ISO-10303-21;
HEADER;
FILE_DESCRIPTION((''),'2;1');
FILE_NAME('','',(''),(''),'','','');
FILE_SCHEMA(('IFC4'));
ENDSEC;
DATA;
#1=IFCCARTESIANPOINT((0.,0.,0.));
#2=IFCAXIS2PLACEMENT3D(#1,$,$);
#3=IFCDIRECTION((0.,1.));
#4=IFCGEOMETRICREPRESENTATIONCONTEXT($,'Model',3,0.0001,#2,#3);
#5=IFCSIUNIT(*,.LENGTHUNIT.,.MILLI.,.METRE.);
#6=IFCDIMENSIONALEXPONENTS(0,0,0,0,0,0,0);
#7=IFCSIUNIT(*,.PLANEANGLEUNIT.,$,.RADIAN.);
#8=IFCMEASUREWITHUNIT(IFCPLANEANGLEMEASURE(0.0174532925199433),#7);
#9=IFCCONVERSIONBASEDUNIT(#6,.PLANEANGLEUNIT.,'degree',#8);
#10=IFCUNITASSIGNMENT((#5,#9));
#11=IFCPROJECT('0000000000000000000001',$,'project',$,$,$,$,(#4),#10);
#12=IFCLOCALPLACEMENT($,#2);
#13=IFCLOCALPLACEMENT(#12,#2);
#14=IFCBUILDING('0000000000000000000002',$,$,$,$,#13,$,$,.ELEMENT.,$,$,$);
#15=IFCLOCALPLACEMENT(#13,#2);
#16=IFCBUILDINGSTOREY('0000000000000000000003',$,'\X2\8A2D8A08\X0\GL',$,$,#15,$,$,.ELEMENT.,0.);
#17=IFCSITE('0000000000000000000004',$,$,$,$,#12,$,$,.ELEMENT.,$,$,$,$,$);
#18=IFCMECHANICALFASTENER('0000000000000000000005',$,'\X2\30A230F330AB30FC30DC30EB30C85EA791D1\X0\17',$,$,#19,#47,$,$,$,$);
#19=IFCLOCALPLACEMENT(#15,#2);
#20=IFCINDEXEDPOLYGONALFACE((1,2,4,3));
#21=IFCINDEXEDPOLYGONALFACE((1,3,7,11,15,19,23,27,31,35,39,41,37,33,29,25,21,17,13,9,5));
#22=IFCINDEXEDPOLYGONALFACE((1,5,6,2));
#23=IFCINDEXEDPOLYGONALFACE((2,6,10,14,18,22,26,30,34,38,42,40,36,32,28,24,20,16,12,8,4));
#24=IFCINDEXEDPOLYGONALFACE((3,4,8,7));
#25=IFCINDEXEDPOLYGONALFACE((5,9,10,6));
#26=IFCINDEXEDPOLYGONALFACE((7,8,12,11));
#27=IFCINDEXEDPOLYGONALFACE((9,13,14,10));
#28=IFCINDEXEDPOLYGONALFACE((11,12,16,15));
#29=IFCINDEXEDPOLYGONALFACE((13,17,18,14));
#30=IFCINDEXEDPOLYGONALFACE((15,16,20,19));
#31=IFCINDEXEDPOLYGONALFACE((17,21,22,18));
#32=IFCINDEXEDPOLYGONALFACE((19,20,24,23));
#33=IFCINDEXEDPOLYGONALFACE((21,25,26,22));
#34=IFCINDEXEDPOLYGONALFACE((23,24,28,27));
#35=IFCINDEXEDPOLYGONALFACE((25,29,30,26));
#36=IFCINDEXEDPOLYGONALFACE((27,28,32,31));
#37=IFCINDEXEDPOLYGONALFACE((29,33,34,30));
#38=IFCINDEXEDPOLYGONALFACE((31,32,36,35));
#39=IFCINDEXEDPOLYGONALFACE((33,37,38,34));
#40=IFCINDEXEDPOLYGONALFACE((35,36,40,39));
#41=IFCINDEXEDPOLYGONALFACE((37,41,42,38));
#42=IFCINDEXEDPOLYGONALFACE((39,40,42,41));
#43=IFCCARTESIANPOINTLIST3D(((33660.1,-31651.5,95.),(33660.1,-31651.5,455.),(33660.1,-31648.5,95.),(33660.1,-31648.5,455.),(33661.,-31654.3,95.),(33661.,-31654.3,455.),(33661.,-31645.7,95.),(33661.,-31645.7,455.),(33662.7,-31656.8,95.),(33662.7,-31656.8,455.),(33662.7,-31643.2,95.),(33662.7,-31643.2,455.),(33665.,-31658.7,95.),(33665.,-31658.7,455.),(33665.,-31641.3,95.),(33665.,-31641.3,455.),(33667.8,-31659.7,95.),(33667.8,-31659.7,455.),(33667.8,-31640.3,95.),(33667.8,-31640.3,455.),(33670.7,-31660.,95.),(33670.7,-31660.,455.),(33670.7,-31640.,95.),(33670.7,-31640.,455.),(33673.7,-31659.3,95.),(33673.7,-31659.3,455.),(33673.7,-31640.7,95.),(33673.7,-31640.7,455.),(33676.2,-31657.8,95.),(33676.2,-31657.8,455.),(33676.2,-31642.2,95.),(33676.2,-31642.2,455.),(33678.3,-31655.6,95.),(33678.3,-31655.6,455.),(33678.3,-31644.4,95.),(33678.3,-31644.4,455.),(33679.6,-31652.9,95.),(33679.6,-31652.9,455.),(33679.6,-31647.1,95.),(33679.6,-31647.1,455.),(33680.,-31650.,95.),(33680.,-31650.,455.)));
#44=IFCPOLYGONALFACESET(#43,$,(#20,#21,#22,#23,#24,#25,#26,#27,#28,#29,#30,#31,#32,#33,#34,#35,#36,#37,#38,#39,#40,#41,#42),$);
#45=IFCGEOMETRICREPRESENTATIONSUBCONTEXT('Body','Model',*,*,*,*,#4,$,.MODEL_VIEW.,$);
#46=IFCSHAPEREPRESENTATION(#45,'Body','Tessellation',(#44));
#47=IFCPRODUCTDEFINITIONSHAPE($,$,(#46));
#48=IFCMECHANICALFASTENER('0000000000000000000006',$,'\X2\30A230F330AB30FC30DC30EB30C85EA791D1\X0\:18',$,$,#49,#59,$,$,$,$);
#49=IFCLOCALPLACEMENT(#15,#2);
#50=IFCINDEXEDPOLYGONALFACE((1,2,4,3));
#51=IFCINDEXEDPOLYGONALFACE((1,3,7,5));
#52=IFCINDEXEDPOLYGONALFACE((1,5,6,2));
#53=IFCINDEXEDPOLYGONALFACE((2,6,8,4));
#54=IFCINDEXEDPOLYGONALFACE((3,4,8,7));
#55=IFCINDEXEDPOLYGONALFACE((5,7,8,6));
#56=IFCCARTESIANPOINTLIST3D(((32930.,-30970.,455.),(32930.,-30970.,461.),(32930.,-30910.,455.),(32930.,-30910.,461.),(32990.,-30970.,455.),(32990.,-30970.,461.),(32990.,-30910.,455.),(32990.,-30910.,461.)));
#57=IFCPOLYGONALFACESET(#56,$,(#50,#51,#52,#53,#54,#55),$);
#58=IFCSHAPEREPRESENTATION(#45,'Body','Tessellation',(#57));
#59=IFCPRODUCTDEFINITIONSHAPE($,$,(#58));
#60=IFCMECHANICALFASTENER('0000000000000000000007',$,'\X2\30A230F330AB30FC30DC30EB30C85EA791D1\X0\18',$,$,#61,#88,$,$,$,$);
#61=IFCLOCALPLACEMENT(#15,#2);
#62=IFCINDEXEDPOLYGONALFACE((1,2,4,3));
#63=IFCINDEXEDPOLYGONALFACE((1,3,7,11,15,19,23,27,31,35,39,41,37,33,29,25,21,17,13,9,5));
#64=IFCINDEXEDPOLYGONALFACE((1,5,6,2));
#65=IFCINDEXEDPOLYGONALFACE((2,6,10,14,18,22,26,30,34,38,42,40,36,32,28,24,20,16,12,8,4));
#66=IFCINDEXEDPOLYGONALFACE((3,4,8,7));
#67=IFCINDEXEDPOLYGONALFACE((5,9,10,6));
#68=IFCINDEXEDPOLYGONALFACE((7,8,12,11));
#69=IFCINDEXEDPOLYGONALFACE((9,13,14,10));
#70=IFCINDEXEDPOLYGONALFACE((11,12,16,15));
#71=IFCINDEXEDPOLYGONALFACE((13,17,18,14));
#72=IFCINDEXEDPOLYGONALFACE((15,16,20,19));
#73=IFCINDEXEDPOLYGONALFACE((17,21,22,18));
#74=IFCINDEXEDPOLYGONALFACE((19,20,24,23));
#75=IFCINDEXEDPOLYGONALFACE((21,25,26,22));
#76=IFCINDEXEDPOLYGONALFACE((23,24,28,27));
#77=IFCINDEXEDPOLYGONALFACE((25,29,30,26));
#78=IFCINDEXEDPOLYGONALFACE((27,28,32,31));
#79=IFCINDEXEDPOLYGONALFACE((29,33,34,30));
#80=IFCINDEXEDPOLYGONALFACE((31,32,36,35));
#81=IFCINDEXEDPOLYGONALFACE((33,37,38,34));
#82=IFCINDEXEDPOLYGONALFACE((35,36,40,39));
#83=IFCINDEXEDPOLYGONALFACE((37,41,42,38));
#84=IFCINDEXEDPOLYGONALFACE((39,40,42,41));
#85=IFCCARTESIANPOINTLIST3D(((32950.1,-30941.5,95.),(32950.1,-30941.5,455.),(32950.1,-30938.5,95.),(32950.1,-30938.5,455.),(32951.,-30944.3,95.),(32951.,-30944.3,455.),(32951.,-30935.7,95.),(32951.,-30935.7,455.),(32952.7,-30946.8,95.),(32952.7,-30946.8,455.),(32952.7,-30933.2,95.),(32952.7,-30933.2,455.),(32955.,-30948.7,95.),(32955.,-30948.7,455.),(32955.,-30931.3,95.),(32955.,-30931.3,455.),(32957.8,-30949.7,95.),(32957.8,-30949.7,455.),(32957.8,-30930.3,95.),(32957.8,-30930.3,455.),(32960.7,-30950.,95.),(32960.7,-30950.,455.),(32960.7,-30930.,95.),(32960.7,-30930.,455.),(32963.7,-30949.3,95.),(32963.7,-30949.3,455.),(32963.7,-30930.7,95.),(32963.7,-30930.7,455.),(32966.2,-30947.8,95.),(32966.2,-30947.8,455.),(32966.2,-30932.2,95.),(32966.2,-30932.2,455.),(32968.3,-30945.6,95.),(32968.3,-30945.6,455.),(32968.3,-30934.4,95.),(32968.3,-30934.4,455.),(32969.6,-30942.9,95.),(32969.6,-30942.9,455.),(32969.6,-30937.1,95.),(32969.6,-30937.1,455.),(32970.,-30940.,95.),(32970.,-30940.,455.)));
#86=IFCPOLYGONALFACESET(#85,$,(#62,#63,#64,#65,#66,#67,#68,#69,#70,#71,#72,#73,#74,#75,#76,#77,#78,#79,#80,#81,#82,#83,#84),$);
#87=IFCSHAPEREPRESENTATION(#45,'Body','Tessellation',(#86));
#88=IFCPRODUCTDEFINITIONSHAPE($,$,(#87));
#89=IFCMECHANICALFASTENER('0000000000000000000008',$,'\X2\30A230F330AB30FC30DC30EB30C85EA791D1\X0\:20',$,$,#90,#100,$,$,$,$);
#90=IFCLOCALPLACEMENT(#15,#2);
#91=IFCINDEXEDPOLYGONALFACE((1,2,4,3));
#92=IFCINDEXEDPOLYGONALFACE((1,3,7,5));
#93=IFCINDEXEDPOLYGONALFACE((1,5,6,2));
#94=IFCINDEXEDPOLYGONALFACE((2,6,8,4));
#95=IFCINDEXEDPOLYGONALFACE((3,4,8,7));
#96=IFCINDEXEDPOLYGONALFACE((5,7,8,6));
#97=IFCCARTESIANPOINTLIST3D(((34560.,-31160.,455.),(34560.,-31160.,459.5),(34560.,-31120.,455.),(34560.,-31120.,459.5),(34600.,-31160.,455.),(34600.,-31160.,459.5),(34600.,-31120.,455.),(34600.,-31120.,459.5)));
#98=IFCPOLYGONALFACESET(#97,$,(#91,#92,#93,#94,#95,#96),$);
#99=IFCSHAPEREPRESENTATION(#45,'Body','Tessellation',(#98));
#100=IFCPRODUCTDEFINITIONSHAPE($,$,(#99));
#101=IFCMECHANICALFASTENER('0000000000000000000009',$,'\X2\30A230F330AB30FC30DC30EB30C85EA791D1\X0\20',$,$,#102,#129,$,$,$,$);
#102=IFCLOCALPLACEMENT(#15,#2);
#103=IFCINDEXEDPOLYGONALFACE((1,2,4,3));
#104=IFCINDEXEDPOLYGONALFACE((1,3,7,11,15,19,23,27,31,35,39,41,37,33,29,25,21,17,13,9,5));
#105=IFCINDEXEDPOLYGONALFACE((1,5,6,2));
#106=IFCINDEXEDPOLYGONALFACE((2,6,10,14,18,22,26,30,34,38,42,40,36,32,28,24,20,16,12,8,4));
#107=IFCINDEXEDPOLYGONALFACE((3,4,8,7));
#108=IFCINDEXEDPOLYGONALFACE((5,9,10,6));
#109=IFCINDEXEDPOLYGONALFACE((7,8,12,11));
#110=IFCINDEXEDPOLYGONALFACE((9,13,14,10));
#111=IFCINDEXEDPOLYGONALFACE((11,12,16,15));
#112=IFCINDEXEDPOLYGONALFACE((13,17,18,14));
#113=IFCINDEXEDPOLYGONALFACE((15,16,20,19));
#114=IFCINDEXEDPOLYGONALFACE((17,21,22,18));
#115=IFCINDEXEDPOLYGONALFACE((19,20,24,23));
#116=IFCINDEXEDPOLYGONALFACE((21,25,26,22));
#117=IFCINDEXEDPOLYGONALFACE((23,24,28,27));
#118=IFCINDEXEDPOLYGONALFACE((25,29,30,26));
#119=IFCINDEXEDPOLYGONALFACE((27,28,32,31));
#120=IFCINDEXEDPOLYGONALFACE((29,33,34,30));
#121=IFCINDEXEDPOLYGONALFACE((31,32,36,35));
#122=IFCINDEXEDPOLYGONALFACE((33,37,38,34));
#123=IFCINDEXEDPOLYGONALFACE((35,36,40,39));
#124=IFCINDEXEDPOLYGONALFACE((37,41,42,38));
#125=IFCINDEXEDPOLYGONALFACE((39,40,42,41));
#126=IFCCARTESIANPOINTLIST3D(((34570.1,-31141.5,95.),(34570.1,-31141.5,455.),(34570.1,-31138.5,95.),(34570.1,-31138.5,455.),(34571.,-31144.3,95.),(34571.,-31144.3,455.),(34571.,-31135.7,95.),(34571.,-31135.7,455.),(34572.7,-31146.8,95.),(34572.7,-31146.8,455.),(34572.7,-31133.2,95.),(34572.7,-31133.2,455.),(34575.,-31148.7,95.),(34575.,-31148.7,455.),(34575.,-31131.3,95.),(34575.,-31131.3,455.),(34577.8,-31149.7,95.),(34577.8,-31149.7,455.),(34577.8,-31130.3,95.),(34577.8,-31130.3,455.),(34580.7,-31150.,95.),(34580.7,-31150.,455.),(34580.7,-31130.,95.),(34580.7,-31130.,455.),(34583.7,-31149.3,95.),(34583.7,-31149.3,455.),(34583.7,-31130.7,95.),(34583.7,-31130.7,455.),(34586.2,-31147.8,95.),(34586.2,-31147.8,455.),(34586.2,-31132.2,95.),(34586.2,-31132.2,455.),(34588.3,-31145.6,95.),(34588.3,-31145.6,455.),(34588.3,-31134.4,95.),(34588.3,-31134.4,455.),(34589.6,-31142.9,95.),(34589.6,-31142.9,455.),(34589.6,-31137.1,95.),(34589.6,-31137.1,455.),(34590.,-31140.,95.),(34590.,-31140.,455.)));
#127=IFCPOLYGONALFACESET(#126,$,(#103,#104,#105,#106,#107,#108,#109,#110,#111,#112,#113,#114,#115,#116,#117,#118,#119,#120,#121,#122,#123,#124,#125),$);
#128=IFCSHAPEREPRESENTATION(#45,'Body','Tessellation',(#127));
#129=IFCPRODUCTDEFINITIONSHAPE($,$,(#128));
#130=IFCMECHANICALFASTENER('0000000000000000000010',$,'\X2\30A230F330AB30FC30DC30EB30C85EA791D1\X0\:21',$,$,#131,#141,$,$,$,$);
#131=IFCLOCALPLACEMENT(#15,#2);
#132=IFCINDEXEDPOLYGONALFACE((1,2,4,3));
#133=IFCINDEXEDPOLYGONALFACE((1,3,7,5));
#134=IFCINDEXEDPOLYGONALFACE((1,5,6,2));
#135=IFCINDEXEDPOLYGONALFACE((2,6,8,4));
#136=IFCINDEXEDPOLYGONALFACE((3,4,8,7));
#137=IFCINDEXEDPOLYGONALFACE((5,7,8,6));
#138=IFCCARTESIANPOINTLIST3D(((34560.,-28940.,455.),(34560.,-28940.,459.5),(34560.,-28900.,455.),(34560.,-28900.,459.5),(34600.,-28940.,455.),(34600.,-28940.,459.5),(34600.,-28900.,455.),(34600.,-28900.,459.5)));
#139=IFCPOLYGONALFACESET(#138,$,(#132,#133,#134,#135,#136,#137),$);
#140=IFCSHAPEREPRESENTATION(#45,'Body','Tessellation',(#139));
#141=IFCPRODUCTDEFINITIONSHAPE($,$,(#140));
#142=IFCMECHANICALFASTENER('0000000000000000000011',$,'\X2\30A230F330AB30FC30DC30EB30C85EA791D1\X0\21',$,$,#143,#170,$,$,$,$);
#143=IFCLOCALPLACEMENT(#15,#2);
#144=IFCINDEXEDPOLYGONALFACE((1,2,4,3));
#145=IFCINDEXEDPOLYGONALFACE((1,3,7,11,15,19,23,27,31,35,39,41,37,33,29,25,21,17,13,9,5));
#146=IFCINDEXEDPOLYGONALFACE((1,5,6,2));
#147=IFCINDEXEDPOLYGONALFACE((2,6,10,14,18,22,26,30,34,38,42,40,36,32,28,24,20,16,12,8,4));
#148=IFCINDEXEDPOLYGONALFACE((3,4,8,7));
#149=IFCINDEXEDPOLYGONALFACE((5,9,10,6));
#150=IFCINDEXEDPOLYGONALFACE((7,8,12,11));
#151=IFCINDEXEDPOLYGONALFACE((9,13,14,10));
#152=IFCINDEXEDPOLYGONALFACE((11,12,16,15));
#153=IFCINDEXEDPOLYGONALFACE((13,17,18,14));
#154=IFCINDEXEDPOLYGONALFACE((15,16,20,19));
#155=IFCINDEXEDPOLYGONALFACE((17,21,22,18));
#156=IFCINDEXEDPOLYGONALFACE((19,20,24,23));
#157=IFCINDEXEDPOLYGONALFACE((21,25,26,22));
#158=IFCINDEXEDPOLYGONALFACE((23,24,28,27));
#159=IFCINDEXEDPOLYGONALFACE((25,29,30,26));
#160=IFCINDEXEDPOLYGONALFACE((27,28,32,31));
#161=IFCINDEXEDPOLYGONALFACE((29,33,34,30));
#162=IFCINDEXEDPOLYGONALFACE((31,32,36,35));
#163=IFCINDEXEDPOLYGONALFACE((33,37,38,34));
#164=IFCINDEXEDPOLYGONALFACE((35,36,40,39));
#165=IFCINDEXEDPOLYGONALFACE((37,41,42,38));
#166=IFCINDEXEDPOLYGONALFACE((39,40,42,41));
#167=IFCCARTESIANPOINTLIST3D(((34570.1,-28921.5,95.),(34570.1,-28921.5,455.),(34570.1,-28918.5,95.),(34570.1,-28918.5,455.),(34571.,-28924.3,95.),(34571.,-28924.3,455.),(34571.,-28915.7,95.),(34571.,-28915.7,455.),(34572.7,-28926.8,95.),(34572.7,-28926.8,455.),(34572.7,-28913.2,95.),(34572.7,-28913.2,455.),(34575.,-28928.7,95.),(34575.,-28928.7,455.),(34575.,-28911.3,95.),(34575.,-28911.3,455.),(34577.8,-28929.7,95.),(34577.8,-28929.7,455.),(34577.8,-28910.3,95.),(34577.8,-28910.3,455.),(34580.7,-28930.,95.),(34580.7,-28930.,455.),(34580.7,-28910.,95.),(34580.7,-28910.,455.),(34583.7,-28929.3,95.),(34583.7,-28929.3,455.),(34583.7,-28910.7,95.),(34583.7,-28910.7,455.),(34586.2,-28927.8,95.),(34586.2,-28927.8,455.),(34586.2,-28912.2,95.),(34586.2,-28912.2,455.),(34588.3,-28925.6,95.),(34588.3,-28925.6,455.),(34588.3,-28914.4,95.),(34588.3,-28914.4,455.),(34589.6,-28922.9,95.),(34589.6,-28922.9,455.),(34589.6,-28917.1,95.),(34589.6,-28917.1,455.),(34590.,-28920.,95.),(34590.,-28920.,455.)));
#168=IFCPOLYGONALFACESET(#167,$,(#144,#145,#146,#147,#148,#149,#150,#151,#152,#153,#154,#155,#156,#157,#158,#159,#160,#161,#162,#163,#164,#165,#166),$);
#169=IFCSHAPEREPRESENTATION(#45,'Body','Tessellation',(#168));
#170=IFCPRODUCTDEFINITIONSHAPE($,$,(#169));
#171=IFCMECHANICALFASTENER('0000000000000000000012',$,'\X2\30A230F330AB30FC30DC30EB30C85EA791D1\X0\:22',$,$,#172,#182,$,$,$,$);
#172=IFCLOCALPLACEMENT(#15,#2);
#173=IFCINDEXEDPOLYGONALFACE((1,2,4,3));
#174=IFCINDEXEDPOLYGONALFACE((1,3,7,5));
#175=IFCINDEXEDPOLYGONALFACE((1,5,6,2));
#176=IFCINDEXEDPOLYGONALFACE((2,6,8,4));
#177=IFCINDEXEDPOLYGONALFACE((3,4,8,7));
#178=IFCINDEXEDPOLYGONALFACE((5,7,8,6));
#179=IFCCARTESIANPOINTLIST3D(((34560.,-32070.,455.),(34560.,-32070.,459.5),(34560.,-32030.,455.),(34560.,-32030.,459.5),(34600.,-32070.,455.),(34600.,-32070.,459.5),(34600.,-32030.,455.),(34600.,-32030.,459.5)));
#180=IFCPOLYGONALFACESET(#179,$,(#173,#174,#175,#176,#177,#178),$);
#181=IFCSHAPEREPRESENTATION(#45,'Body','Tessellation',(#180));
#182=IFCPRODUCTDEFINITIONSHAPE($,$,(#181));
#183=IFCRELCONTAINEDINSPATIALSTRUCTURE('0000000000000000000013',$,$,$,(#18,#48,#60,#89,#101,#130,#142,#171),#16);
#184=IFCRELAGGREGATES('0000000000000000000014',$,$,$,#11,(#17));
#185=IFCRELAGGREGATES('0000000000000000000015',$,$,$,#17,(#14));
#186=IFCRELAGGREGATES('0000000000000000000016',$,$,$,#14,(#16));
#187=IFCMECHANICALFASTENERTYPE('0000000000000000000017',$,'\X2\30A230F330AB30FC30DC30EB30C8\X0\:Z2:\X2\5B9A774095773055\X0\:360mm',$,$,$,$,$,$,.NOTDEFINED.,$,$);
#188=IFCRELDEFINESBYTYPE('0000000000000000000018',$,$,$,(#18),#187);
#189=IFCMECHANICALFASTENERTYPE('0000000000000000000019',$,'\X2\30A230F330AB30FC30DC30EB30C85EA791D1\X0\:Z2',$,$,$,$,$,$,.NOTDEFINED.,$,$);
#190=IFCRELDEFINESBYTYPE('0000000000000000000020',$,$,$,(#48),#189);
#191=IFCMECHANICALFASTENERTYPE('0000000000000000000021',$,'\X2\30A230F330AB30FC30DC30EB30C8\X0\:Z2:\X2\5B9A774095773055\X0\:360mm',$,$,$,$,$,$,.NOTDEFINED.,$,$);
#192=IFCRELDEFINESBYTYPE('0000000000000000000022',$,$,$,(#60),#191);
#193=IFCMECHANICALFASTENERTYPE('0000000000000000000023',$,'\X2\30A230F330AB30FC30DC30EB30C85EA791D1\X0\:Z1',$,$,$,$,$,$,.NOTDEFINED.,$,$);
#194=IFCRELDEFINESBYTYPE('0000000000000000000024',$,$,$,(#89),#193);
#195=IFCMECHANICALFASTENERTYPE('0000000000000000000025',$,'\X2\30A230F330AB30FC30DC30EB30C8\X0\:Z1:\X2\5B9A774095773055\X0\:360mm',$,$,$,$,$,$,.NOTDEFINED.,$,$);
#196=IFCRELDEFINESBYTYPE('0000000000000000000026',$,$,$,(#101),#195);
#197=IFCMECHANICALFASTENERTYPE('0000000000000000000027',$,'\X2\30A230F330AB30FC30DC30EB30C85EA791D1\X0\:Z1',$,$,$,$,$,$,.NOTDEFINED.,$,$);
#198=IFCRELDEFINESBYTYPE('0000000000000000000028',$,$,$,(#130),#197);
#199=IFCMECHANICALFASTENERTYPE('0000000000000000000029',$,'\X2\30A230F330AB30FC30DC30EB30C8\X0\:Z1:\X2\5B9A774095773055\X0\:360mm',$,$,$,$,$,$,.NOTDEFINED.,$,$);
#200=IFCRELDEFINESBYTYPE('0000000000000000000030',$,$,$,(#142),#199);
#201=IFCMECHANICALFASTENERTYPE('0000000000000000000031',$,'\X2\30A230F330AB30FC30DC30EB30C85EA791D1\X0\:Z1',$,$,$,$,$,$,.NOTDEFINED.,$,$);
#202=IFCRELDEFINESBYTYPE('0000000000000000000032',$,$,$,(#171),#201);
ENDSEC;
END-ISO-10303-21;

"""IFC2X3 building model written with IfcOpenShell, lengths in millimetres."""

from ifc_helpers import new_model, entity, si_unit, converted_unit, direction, frame, origin, origin_with_axes, origin_2d, place, context, subcontext, project, spatial, rectangle, circle, extrude, type_object, element, save


model = new_model("IFC2X3")

# Units and contexts
model_context = context("Model", 3, precision=0.0001, world=origin(), true_north=direction((0.0, 1.0)))
body_context = subcontext(model_context, "Body", "Model", "MODEL_VIEW")
ifc_project = project(units=[si_unit("LENGTHUNIT", "METRE", prefix="MILLI"), converted_unit("PLANEANGLEUNIT", "degree", entity("IfcPlaneAngleMeasure", 0.0174532925199433), si_unit("PLANEANGLEUNIT", "RADIAN"), dimensions=[0, 0, 0, 0, 0, 0, 0])], contexts=[model_context])

# Site, building, storey
site_placement = place(None, origin())
site = spatial("IfcSite", under=ifc_project, at=site_placement, CompositionType="ELEMENT")
building_placement = place(site_placement, origin())
building = spatial("IfcBuilding", under=site, at=building_placement, CompositionType="ELEMENT")
storey_placement = place(building_placement, origin())
storey = spatial("IfcBuildingStorey", under=building, at=storey_placement, Name="設計GL", CompositionType="ELEMENT", Elevation=0.0)

# Mechanical fasteners
mechanical_fastener_type_1 = type_object("IfcMechanicalFastenerType", Name="アンカーボルト:Z2:定着長さ:360mm")
mechanical_fastener_1_placement = place(storey_placement, frame((33670.0, -31650.0, 95.0)))
element("IfcMechanicalFastener", 1, at=mechanical_fastener_1_placement, inside=storey, type_object=mechanical_fastener_type_1, Name="アンカーボルト座金17", context=body_context, shape_type="SweptSolid", body=[
    extrude(circle(Radius=10.0, at=origin_2d()), origin_with_axes(), (0.0, 0.0, 1.0), 360.0),
])
mechanical_fastener_type_2 = type_object("IfcMechanicalFastenerType", Name="アンカーボルト座金:Z2")
mechanical_fastener_2_placement = place(storey_placement, frame((32960.0, -30940.0, 455.0)))
element("IfcMechanicalFastener", 2, at=mechanical_fastener_2_placement, inside=storey, type_object=mechanical_fastener_type_2, Name="アンカーボルト座金:18", context=body_context, shape_type="SweptSolid", body=[
    extrude(rectangle(XDim=60.0, YDim=60.0, at=origin_2d()), origin_with_axes(), (0.0, 0.0, 1.0), 6.0),
])
mechanical_fastener_type_3 = type_object("IfcMechanicalFastenerType", Name="アンカーボルト:Z2:定着長さ:360mm")
mechanical_fastener_3_placement = place(storey_placement, frame((32960.0, -30940.0, 95.0)))
element("IfcMechanicalFastener", 3, at=mechanical_fastener_3_placement, inside=storey, type_object=mechanical_fastener_type_3, Name="アンカーボルト座金18", context=body_context, shape_type="SweptSolid", body=[
    extrude(circle(Radius=10.0, at=origin_2d()), origin_with_axes(), (0.0, 0.0, 1.0), 360.0),
])
mechanical_fastener_type_4 = type_object("IfcMechanicalFastenerType", Name="アンカーボルト座金:Z1")
mechanical_fastener_4_placement = place(storey_placement, frame((34580.0, -31140.0, 455.0)))
element("IfcMechanicalFastener", 4, at=mechanical_fastener_4_placement, inside=storey, type_object=mechanical_fastener_type_4, Name="アンカーボルト座金:20", context=body_context, shape_type="SweptSolid", body=[
    extrude(rectangle(XDim=40.0, YDim=40.0, at=origin_2d()), origin_with_axes(), (0.0, 0.0, 1.0), 4.5),
])
mechanical_fastener_type_5 = type_object("IfcMechanicalFastenerType", Name="アンカーボルト:Z1:定着長さ:360mm")
mechanical_fastener_5_placement = place(storey_placement, frame((34580.0, -31140.0, 95.0)))
element("IfcMechanicalFastener", 5, at=mechanical_fastener_5_placement, inside=storey, type_object=mechanical_fastener_type_5, Name="アンカーボルト座金20", context=body_context, shape_type="SweptSolid", body=[
    extrude(circle(Radius=10.0, at=origin_2d()), origin_with_axes(), (0.0, 0.0, 1.0), 360.0),
])
mechanical_fastener_type_6 = type_object("IfcMechanicalFastenerType", Name="アンカーボルト座金:Z1")
mechanical_fastener_6_placement = place(storey_placement, frame((34580.0, -28920.0, 455.0)))
element("IfcMechanicalFastener", 6, at=mechanical_fastener_6_placement, inside=storey, type_object=mechanical_fastener_type_6, Name="アンカーボルト座金:21", context=body_context, shape_type="SweptSolid", body=[
    extrude(rectangle(XDim=40.0, YDim=40.0, at=origin_2d()), origin_with_axes(), (0.0, 0.0, 1.0), 4.5),
])
mechanical_fastener_type_7 = type_object("IfcMechanicalFastenerType", Name="アンカーボルト:Z1:定着長さ:360mm")
mechanical_fastener_7_placement = place(storey_placement, frame((34580.0, -28920.0, 95.0)))
element("IfcMechanicalFastener", 7, at=mechanical_fastener_7_placement, inside=storey, type_object=mechanical_fastener_type_7, Name="アンカーボルト座金21", context=body_context, shape_type="SweptSolid", body=[
    extrude(circle(Radius=10.0, at=origin_2d()), origin_with_axes(), (0.0, 0.0, 1.0), 360.0),
])
mechanical_fastener_type_8 = type_object("IfcMechanicalFastenerType", Name="アンカーボルト座金:Z1")
mechanical_fastener_8_placement = place(storey_placement, frame((34580.0, -32050.0, 455.0)))
element("IfcMechanicalFastener", 8, at=mechanical_fastener_8_placement, inside=storey, type_object=mechanical_fastener_type_8, Name="アンカーボルト座金:22", context=body_context, shape_type="SweptSolid", body=[
    extrude(rectangle(XDim=40.0, YDim=40.0, at=origin_2d()), origin_with_axes(), (0.0, 0.0, 1.0), 4.5),
])

save(model, "model.ifc")
